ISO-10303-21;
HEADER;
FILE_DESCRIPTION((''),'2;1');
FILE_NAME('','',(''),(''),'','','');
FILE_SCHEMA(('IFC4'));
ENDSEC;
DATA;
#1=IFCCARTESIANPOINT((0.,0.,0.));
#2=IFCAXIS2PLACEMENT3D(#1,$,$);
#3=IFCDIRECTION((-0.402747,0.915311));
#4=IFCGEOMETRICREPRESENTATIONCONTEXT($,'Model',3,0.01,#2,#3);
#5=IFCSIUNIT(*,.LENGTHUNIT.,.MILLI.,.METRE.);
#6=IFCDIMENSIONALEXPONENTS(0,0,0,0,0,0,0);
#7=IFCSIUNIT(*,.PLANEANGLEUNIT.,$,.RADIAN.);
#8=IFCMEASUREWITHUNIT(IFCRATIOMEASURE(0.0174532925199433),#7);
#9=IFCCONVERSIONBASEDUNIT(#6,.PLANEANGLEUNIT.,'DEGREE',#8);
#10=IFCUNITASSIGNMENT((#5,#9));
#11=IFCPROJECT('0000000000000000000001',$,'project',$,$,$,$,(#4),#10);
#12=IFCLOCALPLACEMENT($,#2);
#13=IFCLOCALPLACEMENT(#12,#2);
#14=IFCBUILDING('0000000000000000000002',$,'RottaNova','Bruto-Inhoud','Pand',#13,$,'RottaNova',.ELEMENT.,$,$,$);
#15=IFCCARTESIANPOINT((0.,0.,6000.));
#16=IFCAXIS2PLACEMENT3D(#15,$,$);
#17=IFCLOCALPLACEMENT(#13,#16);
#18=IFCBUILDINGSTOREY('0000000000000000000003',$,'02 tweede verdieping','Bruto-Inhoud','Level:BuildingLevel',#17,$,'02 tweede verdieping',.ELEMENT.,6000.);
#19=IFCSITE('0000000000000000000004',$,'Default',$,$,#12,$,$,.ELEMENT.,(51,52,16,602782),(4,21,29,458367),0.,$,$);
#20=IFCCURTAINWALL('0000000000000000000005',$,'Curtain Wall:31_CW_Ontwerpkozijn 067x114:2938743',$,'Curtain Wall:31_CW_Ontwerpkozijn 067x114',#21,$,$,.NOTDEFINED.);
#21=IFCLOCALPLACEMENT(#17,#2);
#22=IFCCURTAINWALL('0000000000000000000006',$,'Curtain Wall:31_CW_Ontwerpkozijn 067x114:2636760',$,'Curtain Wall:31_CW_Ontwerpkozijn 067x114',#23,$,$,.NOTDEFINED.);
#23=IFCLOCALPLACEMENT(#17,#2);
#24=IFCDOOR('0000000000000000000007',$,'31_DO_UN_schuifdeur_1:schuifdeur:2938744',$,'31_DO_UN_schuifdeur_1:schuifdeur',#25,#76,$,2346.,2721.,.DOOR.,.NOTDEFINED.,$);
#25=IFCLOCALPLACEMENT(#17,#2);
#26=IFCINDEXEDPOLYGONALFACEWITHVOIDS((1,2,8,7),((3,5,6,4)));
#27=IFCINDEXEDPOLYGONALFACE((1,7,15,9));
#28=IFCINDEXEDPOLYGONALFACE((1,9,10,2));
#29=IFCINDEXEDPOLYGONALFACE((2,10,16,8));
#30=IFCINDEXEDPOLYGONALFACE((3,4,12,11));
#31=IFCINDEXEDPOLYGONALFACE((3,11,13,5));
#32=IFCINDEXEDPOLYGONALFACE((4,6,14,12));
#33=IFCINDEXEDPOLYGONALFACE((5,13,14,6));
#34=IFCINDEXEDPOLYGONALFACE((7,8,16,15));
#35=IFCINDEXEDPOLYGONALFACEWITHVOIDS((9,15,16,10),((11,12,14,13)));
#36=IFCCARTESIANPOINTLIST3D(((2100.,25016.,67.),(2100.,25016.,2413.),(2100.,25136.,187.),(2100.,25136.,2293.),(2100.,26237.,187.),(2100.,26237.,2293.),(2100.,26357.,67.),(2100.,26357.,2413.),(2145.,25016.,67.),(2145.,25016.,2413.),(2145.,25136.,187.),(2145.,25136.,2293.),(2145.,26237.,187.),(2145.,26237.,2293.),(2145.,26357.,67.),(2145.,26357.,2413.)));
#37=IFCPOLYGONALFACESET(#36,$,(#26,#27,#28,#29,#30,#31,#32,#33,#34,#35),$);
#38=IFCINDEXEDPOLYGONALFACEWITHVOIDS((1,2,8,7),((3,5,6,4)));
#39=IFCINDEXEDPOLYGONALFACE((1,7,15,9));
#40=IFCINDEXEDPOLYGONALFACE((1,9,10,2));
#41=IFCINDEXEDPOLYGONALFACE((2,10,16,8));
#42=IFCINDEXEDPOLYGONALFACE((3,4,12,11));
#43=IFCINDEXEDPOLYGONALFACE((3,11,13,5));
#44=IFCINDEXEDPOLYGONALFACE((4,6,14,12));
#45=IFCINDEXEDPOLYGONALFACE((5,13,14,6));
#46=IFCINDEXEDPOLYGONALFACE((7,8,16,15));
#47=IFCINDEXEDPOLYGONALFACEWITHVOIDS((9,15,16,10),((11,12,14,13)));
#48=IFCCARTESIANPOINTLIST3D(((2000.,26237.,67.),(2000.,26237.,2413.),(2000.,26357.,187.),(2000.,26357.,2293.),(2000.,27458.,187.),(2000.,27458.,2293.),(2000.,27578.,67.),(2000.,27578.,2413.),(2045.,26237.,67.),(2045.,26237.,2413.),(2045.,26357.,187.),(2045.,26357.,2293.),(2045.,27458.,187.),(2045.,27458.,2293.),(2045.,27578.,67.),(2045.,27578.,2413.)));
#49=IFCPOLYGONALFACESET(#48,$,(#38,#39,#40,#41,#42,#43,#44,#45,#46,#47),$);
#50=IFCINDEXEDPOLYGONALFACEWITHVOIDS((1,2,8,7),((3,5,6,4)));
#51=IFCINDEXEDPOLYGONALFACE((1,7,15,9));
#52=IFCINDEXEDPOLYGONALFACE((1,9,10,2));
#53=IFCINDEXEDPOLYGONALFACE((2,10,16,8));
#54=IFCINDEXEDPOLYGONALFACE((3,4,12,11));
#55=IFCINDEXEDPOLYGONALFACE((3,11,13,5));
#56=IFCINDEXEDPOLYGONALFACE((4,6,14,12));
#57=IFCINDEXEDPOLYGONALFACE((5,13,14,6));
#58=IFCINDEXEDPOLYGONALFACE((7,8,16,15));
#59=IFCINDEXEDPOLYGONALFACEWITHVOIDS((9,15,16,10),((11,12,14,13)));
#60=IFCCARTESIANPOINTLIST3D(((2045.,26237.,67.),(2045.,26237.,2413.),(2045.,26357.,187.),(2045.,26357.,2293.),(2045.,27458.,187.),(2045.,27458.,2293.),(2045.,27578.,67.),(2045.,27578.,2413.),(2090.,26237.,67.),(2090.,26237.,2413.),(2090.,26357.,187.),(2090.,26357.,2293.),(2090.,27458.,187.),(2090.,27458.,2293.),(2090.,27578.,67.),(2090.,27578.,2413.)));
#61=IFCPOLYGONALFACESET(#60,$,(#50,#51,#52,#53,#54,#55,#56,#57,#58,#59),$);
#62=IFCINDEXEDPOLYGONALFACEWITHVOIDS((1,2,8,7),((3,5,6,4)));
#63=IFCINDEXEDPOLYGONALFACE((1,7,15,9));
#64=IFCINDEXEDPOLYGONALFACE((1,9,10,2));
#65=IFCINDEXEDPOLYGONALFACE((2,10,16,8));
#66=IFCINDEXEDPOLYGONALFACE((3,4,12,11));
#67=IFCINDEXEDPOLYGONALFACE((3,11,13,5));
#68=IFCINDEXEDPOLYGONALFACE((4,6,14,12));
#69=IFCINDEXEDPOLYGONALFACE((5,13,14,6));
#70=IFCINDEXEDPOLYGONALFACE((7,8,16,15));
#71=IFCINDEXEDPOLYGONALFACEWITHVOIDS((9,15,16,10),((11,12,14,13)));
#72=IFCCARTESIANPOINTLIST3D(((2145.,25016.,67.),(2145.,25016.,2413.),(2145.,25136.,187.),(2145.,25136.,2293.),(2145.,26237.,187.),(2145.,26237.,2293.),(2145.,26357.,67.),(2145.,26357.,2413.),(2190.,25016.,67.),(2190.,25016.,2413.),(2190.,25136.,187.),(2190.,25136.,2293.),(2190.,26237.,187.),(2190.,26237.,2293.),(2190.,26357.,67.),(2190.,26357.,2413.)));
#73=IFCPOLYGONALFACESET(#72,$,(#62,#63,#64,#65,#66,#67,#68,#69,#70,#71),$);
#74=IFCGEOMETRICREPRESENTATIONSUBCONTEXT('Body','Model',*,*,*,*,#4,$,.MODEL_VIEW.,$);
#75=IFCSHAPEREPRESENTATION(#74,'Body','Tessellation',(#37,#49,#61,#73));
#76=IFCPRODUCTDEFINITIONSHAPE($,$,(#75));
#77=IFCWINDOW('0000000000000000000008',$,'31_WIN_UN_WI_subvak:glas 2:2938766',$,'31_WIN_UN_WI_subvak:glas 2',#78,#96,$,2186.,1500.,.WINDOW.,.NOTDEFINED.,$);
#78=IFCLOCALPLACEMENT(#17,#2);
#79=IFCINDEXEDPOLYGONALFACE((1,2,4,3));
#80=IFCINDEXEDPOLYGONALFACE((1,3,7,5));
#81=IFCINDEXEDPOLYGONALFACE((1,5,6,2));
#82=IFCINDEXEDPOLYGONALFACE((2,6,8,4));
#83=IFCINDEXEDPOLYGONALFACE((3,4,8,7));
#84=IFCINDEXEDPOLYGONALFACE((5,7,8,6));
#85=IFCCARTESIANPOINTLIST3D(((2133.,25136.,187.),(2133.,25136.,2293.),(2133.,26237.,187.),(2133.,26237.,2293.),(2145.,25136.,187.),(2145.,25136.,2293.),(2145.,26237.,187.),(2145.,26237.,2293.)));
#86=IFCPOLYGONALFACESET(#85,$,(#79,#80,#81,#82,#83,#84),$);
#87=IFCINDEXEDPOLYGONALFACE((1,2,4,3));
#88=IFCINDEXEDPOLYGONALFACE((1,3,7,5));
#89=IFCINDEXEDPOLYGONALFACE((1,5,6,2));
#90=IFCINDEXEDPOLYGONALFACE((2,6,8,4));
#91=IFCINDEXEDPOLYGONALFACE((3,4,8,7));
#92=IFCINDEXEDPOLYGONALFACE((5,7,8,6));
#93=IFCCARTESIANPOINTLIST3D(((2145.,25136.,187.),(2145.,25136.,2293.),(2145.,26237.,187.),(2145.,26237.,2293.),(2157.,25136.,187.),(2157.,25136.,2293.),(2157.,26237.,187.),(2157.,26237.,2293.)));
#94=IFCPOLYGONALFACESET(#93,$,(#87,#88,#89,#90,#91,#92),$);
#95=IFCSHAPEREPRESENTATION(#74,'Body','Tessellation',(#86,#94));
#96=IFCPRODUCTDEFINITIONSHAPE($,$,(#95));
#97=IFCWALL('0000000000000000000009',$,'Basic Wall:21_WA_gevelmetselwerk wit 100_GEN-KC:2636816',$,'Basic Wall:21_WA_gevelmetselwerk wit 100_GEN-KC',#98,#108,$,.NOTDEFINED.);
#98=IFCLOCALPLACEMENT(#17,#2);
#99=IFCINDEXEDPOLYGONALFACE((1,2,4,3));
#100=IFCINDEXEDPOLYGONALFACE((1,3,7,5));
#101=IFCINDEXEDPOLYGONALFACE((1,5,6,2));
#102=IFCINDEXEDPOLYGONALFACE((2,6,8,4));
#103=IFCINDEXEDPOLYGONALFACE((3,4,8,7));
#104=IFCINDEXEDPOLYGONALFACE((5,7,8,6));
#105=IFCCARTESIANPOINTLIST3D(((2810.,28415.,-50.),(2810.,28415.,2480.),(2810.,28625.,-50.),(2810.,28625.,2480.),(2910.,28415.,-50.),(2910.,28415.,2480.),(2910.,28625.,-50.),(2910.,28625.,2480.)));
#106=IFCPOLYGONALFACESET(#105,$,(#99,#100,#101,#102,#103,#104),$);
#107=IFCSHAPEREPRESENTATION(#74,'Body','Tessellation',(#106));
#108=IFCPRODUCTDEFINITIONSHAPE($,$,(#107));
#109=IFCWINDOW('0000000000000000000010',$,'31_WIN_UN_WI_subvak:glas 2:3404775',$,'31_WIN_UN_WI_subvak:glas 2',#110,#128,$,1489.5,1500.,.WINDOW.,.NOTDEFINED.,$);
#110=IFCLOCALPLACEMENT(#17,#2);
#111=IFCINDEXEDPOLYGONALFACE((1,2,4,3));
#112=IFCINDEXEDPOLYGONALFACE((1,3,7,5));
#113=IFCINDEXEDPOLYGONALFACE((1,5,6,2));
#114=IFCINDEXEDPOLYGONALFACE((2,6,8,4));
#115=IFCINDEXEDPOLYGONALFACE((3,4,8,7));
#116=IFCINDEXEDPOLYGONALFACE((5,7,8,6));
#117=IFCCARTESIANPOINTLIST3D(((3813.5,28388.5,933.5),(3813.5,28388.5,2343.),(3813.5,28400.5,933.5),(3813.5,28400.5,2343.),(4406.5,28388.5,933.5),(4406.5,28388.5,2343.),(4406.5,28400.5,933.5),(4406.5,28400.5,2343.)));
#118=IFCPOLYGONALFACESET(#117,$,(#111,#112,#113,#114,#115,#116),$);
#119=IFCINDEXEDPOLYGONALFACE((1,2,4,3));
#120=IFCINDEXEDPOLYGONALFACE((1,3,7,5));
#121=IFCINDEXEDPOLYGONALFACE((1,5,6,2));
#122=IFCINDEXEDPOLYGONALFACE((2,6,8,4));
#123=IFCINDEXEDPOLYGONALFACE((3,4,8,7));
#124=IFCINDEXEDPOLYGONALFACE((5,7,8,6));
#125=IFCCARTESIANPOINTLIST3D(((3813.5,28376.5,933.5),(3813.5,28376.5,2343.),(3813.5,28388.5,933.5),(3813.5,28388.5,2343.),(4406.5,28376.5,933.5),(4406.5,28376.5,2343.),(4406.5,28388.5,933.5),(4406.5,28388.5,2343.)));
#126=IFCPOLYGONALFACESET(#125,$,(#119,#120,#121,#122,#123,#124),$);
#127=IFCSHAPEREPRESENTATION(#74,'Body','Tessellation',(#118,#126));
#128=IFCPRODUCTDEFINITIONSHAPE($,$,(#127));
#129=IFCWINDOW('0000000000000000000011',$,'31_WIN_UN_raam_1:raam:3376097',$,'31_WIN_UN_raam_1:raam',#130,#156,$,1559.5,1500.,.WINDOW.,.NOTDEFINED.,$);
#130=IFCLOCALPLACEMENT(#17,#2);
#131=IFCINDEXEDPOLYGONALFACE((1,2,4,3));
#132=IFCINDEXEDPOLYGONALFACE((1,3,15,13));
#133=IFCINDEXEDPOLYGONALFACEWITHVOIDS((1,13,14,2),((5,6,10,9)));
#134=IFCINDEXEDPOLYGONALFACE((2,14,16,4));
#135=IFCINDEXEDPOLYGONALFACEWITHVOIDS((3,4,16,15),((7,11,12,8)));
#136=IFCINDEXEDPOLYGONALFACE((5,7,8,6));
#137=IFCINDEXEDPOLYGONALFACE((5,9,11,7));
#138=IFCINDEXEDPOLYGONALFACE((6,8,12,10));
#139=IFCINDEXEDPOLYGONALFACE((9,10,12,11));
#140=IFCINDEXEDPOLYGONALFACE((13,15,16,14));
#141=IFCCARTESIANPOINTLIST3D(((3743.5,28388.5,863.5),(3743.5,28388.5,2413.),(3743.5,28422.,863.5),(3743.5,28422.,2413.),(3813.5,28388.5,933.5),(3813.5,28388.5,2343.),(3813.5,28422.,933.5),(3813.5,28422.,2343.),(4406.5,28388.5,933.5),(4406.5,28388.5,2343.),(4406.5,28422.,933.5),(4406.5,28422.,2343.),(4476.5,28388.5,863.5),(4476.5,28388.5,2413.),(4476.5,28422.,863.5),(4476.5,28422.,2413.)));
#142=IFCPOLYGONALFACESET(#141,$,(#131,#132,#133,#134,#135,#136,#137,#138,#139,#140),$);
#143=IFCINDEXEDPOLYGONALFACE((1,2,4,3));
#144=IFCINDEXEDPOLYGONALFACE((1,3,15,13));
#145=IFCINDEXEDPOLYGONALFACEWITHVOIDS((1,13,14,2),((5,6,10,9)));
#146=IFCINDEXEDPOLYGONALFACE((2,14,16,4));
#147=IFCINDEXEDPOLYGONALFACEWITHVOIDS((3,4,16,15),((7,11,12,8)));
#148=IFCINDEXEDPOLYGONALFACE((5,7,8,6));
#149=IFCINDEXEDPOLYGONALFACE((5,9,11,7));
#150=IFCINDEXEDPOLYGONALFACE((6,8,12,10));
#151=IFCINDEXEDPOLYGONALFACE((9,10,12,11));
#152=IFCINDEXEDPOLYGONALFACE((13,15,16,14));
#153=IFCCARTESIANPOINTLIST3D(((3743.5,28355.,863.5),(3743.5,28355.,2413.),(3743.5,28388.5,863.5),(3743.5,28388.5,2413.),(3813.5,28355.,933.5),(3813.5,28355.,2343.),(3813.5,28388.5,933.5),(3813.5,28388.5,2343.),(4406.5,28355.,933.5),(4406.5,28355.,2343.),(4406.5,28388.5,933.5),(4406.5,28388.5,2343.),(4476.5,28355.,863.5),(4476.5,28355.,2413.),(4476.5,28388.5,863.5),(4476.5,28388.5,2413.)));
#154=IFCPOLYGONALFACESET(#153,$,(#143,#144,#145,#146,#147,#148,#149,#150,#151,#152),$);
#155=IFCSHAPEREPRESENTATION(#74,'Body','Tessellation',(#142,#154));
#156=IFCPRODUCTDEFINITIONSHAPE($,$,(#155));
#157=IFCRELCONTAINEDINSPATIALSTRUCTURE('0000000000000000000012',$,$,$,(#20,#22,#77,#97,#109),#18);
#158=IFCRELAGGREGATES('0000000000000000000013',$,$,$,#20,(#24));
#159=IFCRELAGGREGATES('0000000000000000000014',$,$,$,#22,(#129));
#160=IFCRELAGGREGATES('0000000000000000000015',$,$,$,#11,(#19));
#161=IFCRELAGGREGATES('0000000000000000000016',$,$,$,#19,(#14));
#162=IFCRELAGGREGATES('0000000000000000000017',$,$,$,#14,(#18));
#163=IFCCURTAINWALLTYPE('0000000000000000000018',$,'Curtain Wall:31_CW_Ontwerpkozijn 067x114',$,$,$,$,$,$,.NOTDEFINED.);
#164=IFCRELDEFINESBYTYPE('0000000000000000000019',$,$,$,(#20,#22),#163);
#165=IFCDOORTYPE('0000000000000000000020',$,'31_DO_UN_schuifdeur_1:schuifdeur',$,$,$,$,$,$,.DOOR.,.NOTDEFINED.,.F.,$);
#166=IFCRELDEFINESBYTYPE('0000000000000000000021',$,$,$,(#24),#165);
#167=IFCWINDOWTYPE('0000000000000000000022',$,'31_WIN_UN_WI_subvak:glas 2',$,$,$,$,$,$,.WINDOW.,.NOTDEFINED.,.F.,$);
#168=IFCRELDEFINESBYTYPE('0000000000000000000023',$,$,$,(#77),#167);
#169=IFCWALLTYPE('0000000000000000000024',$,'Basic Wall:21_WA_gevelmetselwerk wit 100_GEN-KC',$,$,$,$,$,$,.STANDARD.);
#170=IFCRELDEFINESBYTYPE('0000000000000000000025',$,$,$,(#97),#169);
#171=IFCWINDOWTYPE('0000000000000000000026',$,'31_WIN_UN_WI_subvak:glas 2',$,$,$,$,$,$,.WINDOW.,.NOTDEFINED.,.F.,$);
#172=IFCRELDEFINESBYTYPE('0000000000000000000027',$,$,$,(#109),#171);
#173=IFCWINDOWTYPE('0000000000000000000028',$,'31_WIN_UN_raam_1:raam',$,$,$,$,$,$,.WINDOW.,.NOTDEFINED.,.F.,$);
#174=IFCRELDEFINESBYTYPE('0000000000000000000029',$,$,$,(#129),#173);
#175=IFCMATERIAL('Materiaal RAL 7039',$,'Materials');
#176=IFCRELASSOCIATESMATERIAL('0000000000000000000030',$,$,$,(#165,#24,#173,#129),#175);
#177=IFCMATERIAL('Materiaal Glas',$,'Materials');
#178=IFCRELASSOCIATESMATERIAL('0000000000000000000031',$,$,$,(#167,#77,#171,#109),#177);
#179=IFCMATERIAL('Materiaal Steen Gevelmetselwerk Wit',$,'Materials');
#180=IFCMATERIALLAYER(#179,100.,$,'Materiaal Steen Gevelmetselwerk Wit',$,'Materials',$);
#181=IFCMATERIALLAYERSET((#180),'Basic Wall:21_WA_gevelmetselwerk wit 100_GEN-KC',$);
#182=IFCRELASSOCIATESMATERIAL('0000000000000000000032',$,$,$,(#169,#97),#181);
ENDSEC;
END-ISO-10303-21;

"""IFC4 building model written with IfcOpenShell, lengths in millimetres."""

from ifc_helpers import new_model, entity, si_unit, converted_unit, direction, frame, frame_2d, origin, origin_2d_with_axis, place, context, subcontext, project, spatial, polyline, rectangle, outline, extrude, source, transform, mapped, material, layer, layer_set, type_object, type_shapes, element, aggregate, save


model = new_model("IFC4")

# Units and contexts
model_context = context("Model", 3, precision=0.01, world=origin(), true_north=direction((-0.402747, 0.915311)))
body_context = subcontext(model_context, "Body", "Model", "MODEL_VIEW")
ifc_project = project(units=[si_unit("LENGTHUNIT", "METRE", prefix="MILLI"), converted_unit("PLANEANGLEUNIT", "DEGREE", entity("IfcRatioMeasure", 0.0174532925199433), si_unit("PLANEANGLEUNIT", "RADIAN"), dimensions=[0, 0, 0, 0, 0, 0, 0])], contexts=[model_context])

# Site, building, storey
site_placement = place(None, origin())
site = spatial("IfcSite", under=ifc_project, at=site_placement, Name="Default", CompositionType="ELEMENT", RefLatitude=(51, 52, 16, 602782), RefLongitude=(4, 21, 29, 458367), RefElevation=0.0)
building_placement = place(site_placement, origin())
building = spatial("IfcBuilding", under=site, at=building_placement, Name="RottaNova", Description="Bruto-Inhoud", ObjectType="Pand", LongName="RottaNova", CompositionType="ELEMENT")
storey_placement = place(building_placement, frame((0.0, 0.0, 6000.0)))
storey = spatial("IfcBuildingStorey", under=building, at=storey_placement, Name="02 tweede verdieping", Description="Bruto-Inhoud", ObjectType="Level:BuildingLevel", LongName="02 tweede verdieping", CompositionType="ELEMENT", Elevation=6000.0)

# Curtain wall
curtain_wall_type = type_object("IfcCurtainWallType", Name="Curtain Wall:31_CW_Ontwerpkozijn 067x114", PredefinedType="NOTDEFINED")
curtain_wall_1_placement = place(storey_placement, frame((0.0, 0.0, -6000.0)))
curtain_wall_1 = element("IfcCurtainWall", 1, at=curtain_wall_1_placement, inside=storey, type_object=curtain_wall_type, Name="Curtain Wall:31_CW_Ontwerpkozijn 067x114:2938743", ObjectType="Curtain Wall:31_CW_Ontwerpkozijn 067x114", PredefinedType="NOTDEFINED")
ifc_material_1 = material(Name="Materiaal RAL 7039", Category="Materials")

# Curtain wall
curtain_wall_2_placement = place(storey_placement, frame((0.0, 0.0, -6000.0)))
curtain_wall_2 = element("IfcCurtainWall", 2, at=curtain_wall_2_placement, inside=storey, type_object=curtain_wall_type, Name="Curtain Wall:31_CW_Ontwerpkozijn 067x114:2636760", ObjectType="Curtain Wall:31_CW_Ontwerpkozijn 067x114", PredefinedType="NOTDEFINED")
ifc_material_2 = material(Name="Materiaal Glas", Category="Materials")

# Door
door_type = type_object("IfcDoorType", Name="31_DO_UN_schuifdeur_1:schuifdeur", OperationType="NOTDEFINED", ParameterTakesPrecedence=False, PredefinedType="DOOR", material=ifc_material_1)
shared_shape_1 = source(origin(), body_context, "Body", "SweptSolid", [
    extrude(outline(polyline([(-670.5, -1173.0), (670.5, -1173.0), (670.5, 1173.0), (-670.5, 1173.0), (-670.5, -1173.0)]), holes=[polyline([(-550.5, -1053.0), (-550.5, 1053.0), (550.5, 1053.0), (550.5, -1053.0), (-550.5, -1053.0)])]), frame((-610.5, 90.0, 1173.0), z_axis=(0.0, -1.0, 0.0), x_axis=(-1.0, 0.0, 0.0)), (0.0, 0.0, 1.0), 45.0),
    extrude(outline(polyline([(-670.5, -1173.0), (670.5, -1173.0), (670.5, 1173.0), (-670.5, 1173.0), (-670.5, -1173.0)]), holes=[polyline([(-550.5, -1053.0), (-550.5, 1053.0), (550.5, 1053.0), (550.5, -1053.0), (-550.5, -1053.0)])]), frame((610.5, 190.0, 1173.0), z_axis=(0.0, -1.0, 0.0), x_axis=(-1.0, 0.0, 0.0)), (0.0, 0.0, 1.0), 45.0),
    extrude(outline(polyline([(-670.5, -1173.0), (670.5, -1173.0), (670.5, 1173.0), (-670.5, 1173.0), (-670.5, -1173.0)]), holes=[polyline([(-550.5, -1053.0), (-550.5, 1053.0), (550.5, 1053.0), (550.5, -1053.0), (-550.5, -1053.0)])]), frame((610.5, 145.0, 1173.0), z_axis=(0.0, -1.0, 0.0), x_axis=(-1.0, 0.0, 0.0)), (0.0, 0.0, 1.0), 45.0),
    extrude(outline(polyline([(-670.5, -1173.0), (670.5, -1173.0), (670.5, 1173.0), (-670.5, 1173.0), (-670.5, -1173.0)]), holes=[polyline([(-550.5, -1053.0), (-550.5, 1053.0), (550.5, 1053.0), (550.5, -1053.0), (-550.5, -1053.0)])]), frame((-610.5, 45.0, 1173.0), z_axis=(0.0, -1.0, 0.0), x_axis=(-1.0, 0.0, 0.0)), (0.0, 0.0, 1.0), 45.0),
])
type_shapes(door_type, [shared_shape_1])
door_placement = place(curtain_wall_1_placement, frame((2190.0, 26297.0, 6067.0), z_axis=(0.0, 0.0, 1.0), x_axis=(0.0, 1.0, 0.0)))
door = element("IfcDoor", 3, at=door_placement, type_object=door_type, material=ifc_material_1, Name="31_DO_UN_schuifdeur_1:schuifdeur:2938744", ObjectType="31_DO_UN_schuifdeur_1:schuifdeur", OperationType="NOTDEFINED", OverallHeight=2346.0, OverallWidth=2721.0, PredefinedType="DOOR", context=body_context, shape_type="MappedRepresentation", body=[
    mapped(shared_shape_1, transform((0.0, 0.0, 0.0), scale=1.0)),
])
aggregate(curtain_wall_1, [door])

# Window
window_type_1 = type_object("IfcWindowType", Name="31_WIN_UN_WI_subvak:glas 2", ParameterTakesPrecedence=False, PartitioningType="NOTDEFINED", PredefinedType="WINDOW", material=ifc_material_2)
shared_shape_2 = source(origin(), body_context, "Body", "SweptSolid", [
    extrude(rectangle(XDim=1101.0, YDim=12.0, at=origin_2d_with_axis()), frame((0.0, -6.0, 0.0)), (0.0, 0.0, 1.0), 2106.0),
    extrude(rectangle(XDim=1101.0, YDim=12.0, at=origin_2d_with_axis()), frame((0.0, 6.0, 0.0)), (0.0, 0.0, 1.0), 2106.0),
])
type_shapes(window_type_1, [shared_shape_2])
window_1_placement = place(storey_placement, frame((2145.0, 25686.5, 187.0), z_axis=(0.0, 0.0, 1.0), x_axis=(0.0, -1.0, 0.0)))
element("IfcWindow", 4, at=window_1_placement, inside=storey, type_object=window_type_1, material=ifc_material_2, Name="31_WIN_UN_WI_subvak:glas 2:2938766", ObjectType="31_WIN_UN_WI_subvak:glas 2", OverallHeight=2186.0, OverallWidth=1500.0, PartitioningType="NOTDEFINED", PredefinedType="WINDOW", context=body_context, shape_type="MappedRepresentation", body=[
    mapped(shared_shape_2, transform((0.0, 0.0, 0.0), scale=1.0)),
])

# Shared definitions
ifc_material_3 = material(Name="Materiaal Steen Gevelmetselwerk Wit", Category="Materials")
ifc_layer_1 = layer(ifc_material_3, 100.0, Name="Materiaal Steen Gevelmetselwerk Wit", Category="Materials")
ifc_layer_set_1 = layer_set([ifc_layer_1], Name="Basic Wall:21_WA_gevelmetselwerk wit 100_GEN-KC")
wall_type_1 = type_object("IfcWallType", Name="Basic Wall:21_WA_gevelmetselwerk wit 100_GEN-KC", PredefinedType="STANDARD", material=ifc_layer_set_1)

# Wall
wall_1_placement = place(storey_placement, frame((2860.0, 28415.0, -50.0), z_axis=(0.0, 0.0, 1.0), x_axis=(0.0, 1.0, 0.0)))
element("IfcWall", 5, at=wall_1_placement, inside=storey, type_object=wall_type_1, material=ifc_layer_set_1, Name="Basic Wall:21_WA_gevelmetselwerk wit 100_GEN-KC:2636816", ObjectType="Basic Wall:21_WA_gevelmetselwerk wit 100_GEN-KC", PredefinedType="NOTDEFINED", context=body_context, shape_type="SweptSolid", body=[
    extrude(rectangle(XDim=210.0, YDim=100.0, at=frame_2d((105.0, 0.0), x_axis=(-1.0, 0.0))), origin(), (0.0, 0.0, 1.0), 2530.0),
])

# Windows
window_type_2 = type_object("IfcWindowType", Name="31_WIN_UN_WI_subvak:glas 2", ParameterTakesPrecedence=False, PartitioningType="NOTDEFINED", PredefinedType="WINDOW", material=ifc_material_2)
shared_shape_3 = source(origin(), body_context, "Body", "SweptSolid", [
    extrude(rectangle(XDim=593.0, YDim=12.0, at=origin_2d_with_axis()), frame((0.0, -6.0, 0.0)), (0.0, 0.0, 1.0), 1409.5),
    extrude(rectangle(XDim=593.0, YDim=12.0, at=origin_2d_with_axis()), frame((0.0, 6.0, 0.0)), (0.0, 0.0, 1.0), 1409.5),
])
type_shapes(window_type_2, [shared_shape_3])
window_2_placement = place(storey_placement, frame((4110.0, 28388.5, 933.5), z_axis=(0.0, 0.0, 1.0), x_axis=(-1.0, 0.0, 0.0)))
element("IfcWindow", 6, at=window_2_placement, inside=storey, type_object=window_type_2, material=ifc_material_2, Name="31_WIN_UN_WI_subvak:glas 2:3404775", ObjectType="31_WIN_UN_WI_subvak:glas 2", OverallHeight=1489.5, OverallWidth=1500.0, PartitioningType="NOTDEFINED", PredefinedType="WINDOW", context=body_context, shape_type="MappedRepresentation", body=[
    mapped(shared_shape_3, transform((0.0, 0.0, 0.0), scale=1.0)),
])
window_type_3 = type_object("IfcWindowType", Name="31_WIN_UN_raam_1:raam", ParameterTakesPrecedence=False, PartitioningType="NOTDEFINED", PredefinedType="WINDOW", material=ifc_material_1)
shared_shape_4 = source(origin(), body_context, "Body", "SweptSolid", [
    extrude(outline(polyline([(-366.5, -774.7), (366.5, -774.7), (366.5, 774.7), (-366.5, 774.7), (-366.5, -774.7)]), holes=[polyline([(-296.5, 704.7), (296.5, 704.7), (296.5, -704.8), (-296.5, -704.8), (-296.5, 704.7)])]), frame((0.0, 92.0, 774.8), z_axis=(0.0, -1.0, 0.0), x_axis=(-1.0, 0.0, 0.0)), (0.0, 0.0, 1.0), 33.5),
    extrude(outline(polyline([(-366.5, -774.7), (366.5, -774.7), (366.5, 774.7), (-366.5, 774.7), (-366.5, -774.7)]), holes=[polyline([(-296.5, 704.7), (296.5, 704.7), (296.5, -704.8), (-296.5, -704.8), (-296.5, 704.7)])]), frame((0.0, 58.5, 774.8), z_axis=(0.0, -1.0, 0.0), x_axis=(-1.0, 0.0, 0.0)), (0.0, 0.0, 1.0), 33.5),
])
type_shapes(window_type_3, [shared_shape_4])
window_3_placement = place(curtain_wall_2_placement, frame((4110.0, 28330.0, 6863.5)))
window_3 = element("IfcWindow", 7, at=window_3_placement, type_object=window_type_3, material=ifc_material_1, Name="31_WIN_UN_raam_1:raam:3376097", ObjectType="31_WIN_UN_raam_1:raam", OverallHeight=1559.5, OverallWidth=1500.0, PartitioningType="NOTDEFINED", PredefinedType="WINDOW", context=body_context, shape_type="MappedRepresentation", body=[
    mapped(shared_shape_4, transform((0.0, 0.0, 0.0), scale=1.0)),
])
aggregate(curtain_wall_2, [window_3])

save(model, "model.ifc")
